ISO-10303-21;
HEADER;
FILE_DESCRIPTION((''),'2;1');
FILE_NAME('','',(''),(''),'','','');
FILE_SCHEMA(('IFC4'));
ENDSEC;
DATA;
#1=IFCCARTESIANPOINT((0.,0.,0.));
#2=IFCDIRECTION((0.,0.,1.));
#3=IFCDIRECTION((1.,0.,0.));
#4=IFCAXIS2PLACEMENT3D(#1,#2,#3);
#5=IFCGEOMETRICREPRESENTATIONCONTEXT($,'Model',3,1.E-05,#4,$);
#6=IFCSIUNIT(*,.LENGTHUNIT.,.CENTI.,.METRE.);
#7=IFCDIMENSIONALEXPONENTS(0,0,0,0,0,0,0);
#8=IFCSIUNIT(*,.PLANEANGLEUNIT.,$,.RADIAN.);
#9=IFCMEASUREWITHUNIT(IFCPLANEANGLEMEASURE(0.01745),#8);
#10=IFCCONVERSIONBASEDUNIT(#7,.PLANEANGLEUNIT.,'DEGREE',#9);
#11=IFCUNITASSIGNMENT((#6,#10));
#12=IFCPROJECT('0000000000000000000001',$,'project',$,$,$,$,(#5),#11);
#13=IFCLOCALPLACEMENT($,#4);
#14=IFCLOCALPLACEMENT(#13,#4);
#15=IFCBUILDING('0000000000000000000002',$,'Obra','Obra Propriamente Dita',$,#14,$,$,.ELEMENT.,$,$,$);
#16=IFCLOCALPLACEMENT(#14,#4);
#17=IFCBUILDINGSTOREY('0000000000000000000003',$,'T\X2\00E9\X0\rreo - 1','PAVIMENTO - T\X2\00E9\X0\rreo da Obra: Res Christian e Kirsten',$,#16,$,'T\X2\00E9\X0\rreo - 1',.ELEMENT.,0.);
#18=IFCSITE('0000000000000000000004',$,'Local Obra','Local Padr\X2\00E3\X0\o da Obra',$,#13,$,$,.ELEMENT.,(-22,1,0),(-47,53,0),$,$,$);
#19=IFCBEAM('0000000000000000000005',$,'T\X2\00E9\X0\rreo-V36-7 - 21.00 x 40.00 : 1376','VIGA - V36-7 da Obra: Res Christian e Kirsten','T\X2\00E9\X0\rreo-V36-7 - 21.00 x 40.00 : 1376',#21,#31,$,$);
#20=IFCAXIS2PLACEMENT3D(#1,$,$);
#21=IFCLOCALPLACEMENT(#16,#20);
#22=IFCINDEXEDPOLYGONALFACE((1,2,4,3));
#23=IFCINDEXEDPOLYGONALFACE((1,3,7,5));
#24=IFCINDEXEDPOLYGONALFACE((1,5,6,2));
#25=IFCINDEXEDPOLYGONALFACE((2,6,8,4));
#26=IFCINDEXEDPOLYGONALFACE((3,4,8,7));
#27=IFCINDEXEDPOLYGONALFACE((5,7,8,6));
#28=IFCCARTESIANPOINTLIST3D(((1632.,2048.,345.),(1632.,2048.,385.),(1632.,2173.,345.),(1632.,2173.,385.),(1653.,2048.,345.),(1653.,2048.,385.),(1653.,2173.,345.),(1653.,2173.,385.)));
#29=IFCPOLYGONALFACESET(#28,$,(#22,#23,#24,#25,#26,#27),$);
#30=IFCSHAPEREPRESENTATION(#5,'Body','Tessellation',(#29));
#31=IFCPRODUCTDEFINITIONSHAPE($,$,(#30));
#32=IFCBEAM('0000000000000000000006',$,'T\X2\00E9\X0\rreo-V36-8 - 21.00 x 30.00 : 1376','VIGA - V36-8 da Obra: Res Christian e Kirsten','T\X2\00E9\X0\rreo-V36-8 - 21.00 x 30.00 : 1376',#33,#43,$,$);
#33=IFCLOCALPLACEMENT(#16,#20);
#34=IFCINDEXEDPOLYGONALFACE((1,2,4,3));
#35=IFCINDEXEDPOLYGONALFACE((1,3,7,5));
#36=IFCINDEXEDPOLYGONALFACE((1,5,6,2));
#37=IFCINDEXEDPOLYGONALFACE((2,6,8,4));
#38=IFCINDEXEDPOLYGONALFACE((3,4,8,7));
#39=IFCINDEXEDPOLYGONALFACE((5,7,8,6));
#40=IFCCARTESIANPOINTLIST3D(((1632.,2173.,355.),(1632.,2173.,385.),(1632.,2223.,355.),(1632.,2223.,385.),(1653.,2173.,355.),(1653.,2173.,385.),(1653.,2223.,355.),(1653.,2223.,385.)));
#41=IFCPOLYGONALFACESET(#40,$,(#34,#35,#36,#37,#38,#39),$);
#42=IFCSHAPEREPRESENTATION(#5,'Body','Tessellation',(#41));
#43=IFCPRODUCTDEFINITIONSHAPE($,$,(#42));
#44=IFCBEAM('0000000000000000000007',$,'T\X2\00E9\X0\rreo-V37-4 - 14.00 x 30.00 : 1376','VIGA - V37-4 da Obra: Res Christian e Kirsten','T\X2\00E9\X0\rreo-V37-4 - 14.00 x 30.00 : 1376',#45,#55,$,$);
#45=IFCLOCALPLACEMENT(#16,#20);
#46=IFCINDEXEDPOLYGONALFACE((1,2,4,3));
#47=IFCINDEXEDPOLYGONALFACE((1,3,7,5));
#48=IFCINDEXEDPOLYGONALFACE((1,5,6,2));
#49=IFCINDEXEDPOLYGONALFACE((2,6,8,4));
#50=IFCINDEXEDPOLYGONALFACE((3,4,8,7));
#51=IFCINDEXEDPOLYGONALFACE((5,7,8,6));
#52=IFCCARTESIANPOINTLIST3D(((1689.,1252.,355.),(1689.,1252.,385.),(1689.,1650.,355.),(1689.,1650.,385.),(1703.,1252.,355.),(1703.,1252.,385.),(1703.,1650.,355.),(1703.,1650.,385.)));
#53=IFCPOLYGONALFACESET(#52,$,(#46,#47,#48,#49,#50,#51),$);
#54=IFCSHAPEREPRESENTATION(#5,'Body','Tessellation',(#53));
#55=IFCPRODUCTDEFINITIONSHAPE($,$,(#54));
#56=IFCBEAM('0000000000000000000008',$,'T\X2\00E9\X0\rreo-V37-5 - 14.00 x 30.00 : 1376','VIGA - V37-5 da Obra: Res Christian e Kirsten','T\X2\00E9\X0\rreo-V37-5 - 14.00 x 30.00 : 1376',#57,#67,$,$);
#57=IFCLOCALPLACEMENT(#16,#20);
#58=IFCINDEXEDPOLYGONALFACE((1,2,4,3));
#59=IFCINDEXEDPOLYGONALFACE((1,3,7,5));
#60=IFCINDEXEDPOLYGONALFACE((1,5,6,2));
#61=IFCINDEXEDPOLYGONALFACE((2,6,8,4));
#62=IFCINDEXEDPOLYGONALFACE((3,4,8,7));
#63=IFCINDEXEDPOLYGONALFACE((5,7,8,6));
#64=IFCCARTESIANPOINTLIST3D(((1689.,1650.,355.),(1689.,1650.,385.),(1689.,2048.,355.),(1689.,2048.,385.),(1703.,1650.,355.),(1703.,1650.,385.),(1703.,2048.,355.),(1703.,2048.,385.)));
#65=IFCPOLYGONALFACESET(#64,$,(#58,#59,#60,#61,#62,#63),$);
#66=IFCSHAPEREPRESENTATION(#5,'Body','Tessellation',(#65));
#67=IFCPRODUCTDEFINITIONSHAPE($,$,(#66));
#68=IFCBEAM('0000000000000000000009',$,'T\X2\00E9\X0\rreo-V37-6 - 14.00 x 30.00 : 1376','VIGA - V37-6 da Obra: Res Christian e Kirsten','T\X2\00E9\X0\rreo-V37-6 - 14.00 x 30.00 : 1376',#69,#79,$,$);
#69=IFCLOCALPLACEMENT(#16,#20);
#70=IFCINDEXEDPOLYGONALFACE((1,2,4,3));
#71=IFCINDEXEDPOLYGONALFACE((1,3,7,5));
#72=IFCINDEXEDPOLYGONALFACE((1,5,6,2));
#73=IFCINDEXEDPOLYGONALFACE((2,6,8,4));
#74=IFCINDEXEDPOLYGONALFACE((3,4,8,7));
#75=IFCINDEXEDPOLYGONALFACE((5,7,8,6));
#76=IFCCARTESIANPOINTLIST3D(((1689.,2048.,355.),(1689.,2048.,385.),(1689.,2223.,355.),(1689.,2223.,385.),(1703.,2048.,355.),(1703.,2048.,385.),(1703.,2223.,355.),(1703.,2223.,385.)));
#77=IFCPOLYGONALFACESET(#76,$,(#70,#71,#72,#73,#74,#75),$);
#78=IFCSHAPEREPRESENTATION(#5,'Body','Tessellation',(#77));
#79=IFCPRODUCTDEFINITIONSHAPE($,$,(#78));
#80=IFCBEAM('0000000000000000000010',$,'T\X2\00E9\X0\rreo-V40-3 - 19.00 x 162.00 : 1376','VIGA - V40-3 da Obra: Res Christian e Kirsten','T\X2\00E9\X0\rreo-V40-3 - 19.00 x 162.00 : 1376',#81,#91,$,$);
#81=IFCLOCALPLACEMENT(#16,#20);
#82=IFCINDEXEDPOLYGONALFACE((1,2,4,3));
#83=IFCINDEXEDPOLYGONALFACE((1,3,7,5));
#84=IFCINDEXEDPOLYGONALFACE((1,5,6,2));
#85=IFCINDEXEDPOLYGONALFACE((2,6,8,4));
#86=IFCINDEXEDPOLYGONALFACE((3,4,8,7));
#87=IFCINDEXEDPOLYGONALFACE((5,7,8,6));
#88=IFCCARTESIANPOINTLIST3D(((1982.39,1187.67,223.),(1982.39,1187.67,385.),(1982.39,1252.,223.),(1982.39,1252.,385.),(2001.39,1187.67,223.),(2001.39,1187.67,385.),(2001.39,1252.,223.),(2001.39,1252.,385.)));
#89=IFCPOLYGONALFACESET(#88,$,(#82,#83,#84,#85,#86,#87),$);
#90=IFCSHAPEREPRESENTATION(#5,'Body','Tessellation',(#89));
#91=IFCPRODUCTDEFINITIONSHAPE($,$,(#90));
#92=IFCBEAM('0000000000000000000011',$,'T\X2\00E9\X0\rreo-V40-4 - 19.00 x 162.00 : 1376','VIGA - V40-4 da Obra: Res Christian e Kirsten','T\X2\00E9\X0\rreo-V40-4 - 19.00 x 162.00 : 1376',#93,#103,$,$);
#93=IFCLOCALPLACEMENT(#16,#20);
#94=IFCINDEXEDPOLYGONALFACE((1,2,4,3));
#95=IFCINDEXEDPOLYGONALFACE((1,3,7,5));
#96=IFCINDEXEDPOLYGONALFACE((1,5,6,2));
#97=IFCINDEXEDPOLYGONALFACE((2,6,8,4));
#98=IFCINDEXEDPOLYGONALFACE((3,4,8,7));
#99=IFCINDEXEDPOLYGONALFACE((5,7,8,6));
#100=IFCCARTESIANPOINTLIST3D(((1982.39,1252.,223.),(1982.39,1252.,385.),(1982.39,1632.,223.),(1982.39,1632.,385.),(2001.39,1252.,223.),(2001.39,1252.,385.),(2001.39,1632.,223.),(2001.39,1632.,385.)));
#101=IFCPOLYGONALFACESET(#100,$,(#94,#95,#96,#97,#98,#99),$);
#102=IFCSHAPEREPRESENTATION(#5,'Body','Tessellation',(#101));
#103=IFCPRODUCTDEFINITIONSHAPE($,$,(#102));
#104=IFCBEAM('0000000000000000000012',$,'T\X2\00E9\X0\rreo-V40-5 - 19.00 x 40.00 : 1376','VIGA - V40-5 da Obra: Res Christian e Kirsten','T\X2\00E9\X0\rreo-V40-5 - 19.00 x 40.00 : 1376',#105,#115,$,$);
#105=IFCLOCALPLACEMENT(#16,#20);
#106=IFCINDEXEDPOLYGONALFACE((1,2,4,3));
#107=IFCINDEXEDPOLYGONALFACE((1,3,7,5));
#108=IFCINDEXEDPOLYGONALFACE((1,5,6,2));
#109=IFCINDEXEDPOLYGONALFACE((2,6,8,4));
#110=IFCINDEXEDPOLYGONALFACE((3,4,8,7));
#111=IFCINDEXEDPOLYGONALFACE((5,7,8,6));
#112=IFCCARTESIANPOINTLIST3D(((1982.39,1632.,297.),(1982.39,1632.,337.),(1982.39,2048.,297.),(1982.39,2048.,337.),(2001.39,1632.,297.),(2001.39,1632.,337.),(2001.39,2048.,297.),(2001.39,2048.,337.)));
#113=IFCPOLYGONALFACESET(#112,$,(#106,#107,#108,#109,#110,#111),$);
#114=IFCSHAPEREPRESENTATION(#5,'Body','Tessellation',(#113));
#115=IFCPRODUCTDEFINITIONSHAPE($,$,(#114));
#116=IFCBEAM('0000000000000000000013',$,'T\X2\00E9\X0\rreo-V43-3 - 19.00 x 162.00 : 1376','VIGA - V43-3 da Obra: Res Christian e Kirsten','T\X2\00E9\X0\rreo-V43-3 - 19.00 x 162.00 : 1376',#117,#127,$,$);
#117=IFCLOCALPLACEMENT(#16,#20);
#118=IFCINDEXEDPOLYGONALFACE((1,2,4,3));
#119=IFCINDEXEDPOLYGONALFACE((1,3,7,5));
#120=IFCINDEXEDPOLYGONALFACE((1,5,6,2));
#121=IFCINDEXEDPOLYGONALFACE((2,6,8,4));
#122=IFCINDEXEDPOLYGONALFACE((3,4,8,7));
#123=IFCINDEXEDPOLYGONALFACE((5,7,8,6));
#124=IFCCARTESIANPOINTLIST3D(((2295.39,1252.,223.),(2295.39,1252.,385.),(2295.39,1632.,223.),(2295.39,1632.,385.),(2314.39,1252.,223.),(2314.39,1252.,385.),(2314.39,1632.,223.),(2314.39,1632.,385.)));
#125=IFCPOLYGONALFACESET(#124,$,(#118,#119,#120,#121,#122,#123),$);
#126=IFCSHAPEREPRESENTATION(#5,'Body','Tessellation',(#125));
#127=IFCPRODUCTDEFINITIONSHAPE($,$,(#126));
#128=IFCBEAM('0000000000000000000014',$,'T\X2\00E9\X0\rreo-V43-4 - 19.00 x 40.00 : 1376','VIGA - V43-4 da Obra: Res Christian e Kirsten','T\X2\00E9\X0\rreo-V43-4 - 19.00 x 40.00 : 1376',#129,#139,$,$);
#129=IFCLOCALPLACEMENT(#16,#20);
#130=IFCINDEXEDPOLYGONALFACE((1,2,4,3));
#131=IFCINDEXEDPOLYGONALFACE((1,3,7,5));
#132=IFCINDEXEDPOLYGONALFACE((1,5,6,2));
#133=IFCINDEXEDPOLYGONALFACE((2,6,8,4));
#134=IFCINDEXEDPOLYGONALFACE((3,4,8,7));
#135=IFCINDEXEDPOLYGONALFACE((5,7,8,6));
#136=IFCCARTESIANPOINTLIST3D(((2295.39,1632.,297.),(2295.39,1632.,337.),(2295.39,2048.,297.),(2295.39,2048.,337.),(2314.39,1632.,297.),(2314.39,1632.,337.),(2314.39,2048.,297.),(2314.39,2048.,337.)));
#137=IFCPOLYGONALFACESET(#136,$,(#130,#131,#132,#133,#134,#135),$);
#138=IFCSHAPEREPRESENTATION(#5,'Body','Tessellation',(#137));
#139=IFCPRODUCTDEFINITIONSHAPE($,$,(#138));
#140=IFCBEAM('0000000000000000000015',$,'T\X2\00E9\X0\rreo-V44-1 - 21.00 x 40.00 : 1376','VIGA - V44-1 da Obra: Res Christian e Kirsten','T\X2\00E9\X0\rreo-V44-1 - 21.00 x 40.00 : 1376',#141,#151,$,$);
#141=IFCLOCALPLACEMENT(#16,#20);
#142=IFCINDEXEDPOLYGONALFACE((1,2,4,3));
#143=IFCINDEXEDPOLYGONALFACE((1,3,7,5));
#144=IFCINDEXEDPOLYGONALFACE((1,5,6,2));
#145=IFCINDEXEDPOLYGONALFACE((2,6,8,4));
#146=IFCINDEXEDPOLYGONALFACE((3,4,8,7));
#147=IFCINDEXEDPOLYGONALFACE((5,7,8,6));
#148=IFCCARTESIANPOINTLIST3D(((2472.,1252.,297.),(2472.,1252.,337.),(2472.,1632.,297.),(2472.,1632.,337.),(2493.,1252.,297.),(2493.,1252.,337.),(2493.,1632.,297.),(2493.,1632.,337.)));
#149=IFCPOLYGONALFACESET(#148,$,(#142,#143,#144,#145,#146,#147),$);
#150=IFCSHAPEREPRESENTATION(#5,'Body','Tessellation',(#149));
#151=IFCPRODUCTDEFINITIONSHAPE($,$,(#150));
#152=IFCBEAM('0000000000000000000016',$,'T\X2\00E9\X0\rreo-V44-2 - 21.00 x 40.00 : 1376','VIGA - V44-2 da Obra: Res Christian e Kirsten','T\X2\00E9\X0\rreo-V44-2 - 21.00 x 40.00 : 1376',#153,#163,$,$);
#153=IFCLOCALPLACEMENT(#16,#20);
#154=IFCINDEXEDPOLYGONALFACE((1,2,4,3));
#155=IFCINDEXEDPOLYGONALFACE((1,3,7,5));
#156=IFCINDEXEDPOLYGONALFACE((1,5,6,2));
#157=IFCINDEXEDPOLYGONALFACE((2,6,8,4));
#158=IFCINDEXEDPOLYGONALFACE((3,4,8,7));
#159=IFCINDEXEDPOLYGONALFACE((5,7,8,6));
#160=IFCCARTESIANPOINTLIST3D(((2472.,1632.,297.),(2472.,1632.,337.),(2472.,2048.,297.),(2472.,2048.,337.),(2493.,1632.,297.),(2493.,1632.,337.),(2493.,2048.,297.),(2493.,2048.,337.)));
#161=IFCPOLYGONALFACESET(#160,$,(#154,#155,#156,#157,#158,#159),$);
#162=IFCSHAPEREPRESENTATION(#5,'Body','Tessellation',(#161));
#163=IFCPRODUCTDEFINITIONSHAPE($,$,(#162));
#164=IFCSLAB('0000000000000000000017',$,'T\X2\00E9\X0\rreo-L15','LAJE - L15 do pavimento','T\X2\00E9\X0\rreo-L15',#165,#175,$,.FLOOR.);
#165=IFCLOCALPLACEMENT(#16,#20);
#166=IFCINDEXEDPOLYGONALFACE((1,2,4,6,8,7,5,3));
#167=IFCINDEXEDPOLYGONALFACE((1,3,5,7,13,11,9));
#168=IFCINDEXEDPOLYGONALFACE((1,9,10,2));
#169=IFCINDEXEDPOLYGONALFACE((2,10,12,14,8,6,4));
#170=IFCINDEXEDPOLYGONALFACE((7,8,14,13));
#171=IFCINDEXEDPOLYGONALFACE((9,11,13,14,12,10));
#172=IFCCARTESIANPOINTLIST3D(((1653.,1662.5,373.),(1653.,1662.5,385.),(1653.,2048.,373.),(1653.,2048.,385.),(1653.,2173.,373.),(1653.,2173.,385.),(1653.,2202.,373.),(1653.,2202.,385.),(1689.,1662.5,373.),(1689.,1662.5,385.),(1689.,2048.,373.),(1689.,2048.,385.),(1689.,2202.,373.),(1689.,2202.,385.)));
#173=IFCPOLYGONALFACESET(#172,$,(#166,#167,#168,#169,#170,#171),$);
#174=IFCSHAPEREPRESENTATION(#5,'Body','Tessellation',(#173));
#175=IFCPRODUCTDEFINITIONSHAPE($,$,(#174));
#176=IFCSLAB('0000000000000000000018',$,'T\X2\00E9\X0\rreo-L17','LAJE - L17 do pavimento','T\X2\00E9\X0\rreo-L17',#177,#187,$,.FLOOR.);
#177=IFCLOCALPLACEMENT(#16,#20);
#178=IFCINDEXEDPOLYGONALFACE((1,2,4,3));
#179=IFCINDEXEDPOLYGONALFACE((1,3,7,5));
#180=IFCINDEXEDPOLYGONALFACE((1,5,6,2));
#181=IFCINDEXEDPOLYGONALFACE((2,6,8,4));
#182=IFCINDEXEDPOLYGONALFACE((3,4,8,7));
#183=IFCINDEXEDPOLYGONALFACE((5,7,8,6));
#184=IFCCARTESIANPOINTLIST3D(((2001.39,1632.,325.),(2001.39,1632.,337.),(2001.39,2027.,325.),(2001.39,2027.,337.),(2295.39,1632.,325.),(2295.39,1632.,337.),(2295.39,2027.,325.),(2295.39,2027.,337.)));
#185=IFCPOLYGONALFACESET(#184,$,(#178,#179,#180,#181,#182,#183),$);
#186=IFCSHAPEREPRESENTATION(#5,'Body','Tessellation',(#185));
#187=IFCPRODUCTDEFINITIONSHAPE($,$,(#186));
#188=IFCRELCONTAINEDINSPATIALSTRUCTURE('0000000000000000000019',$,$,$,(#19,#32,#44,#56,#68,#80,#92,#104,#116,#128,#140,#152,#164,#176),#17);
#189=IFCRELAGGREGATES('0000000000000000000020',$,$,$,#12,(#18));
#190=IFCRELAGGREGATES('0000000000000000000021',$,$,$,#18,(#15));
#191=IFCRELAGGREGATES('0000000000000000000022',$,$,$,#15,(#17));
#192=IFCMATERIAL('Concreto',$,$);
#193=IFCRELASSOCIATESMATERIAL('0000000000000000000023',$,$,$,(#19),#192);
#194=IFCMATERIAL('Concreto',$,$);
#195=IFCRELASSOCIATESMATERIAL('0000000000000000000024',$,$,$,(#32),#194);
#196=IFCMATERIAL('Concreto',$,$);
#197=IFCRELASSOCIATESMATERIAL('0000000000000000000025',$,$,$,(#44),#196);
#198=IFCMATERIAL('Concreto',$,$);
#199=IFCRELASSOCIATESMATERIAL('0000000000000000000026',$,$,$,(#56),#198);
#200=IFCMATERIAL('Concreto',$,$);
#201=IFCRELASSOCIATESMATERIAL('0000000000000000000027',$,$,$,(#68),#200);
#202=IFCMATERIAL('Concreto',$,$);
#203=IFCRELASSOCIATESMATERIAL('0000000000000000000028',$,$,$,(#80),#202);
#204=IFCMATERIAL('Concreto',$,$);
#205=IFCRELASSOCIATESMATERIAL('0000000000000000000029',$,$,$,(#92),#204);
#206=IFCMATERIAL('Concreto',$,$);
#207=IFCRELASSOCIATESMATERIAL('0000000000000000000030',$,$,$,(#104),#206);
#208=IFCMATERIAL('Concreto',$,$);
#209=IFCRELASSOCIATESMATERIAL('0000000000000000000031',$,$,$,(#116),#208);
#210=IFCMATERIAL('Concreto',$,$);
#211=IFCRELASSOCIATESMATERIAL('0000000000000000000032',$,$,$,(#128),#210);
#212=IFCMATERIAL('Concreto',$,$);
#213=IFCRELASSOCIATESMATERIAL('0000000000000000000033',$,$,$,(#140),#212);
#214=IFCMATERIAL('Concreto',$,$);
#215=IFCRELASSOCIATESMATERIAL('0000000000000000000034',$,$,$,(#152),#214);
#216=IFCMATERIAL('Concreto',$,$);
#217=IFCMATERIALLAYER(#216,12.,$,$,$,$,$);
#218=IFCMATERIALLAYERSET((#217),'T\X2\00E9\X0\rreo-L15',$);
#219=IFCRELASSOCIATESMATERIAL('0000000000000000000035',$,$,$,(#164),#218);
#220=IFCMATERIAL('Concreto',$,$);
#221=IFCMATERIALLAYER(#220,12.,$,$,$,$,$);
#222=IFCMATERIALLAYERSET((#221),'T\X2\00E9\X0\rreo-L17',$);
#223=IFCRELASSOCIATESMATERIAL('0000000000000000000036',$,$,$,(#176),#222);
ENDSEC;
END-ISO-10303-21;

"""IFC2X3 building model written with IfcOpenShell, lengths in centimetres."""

from ifc_helpers import new_model, entity, si_unit, converted_unit, frame, origin_with_axes, place, context, project, spatial, polyline, outline, extrude, material, layer, layer_set, layer_usage, element, save


model = new_model("IFC2X3")

# Units and contexts
model_context = context("Model", 3, precision=1e-05, world=origin_with_axes())
ifc_project = project(units=[si_unit("LENGTHUNIT", "METRE", prefix="CENTI"), converted_unit("PLANEANGLEUNIT", "DEGREE", entity("IfcPlaneAngleMeasure", 0.01745), si_unit("PLANEANGLEUNIT", "RADIAN"), dimensions=[0, 0, 0, 0, 0, 0, 0])], contexts=[model_context])

# Site, building, storey
site_placement = place(None, origin_with_axes())
site = spatial("IfcSite", under=ifc_project, at=site_placement, Name="Local Obra", Description="Local Padrão da Obra", CompositionType="ELEMENT", RefLatitude=(-22, 1, 0), RefLongitude=(-47, 53, 0))
building_placement = place(site_placement, origin_with_axes())
building = spatial("IfcBuilding", under=site, at=building_placement, Name="Obra", Description="Obra Propriamente Dita", CompositionType="ELEMENT")
storey_placement = place(building_placement, origin_with_axes())
storey = spatial("IfcBuildingStorey", under=building, at=storey_placement, Name="Térreo - 1", Description="PAVIMENTO - Térreo da Obra: Res Christian e Kirsten", LongName="Térreo - 1", CompositionType="ELEMENT", Elevation=0.0)

# Beams
ifc_material_1 = material(Name="Concreto")
beam_1_placement = place(storey_placement, frame((1653.0, 2048.0, 385.0), z_axis=(0.0, 1.0, 0.0), x_axis=(1.0, 0.0, 0.0)))
element("IfcBeam", 1, at=beam_1_placement, inside=storey, material=ifc_material_1, Name="Térreo-V36-7 - 21.00 x 40.00 : 1376", Description="VIGA - V36-7 da Obra: Res Christian e Kirsten", ObjectType="Térreo-V36-7 - 21.00 x 40.00 : 1376", context=model_context, shape_type="SweptSolid", body=[
    extrude(outline(polyline([(-21.0, 0.0), (0.0, 0.0), (0.0, 40.0), (-21.0, 40.0), (-21.0, 0.0)])), origin_with_axes(), (0.0, 0.0, 1.0), 125.0),
])
ifc_material_2 = material(Name="Concreto")
beam_2_placement = place(storey_placement, frame((1653.0, 2173.0, 385.0), z_axis=(0.0, 1.0, 0.0), x_axis=(1.0, 0.0, 0.0)))
element("IfcBeam", 2, at=beam_2_placement, inside=storey, material=ifc_material_2, Name="Térreo-V36-8 - 21.00 x 30.00 : 1376", Description="VIGA - V36-8 da Obra: Res Christian e Kirsten", ObjectType="Térreo-V36-8 - 21.00 x 30.00 : 1376", context=model_context, shape_type="SweptSolid", body=[
    extrude(outline(polyline([(-21.0, 0.0), (0.0, 0.0), (0.0, 30.0), (-21.0, 30.0), (-21.0, 0.0)])), origin_with_axes(), (0.0, 0.0, 1.0), 50.0),
])
ifc_material_3 = material(Name="Concreto")
beam_3_placement = place(storey_placement, frame((1703.0, 1252.0, 385.0), z_axis=(0.0, 1.0, 0.0), x_axis=(1.0, 0.0, 0.0)))
element("IfcBeam", 3, at=beam_3_placement, inside=storey, material=ifc_material_3, Name="Térreo-V37-4 - 14.00 x 30.00 : 1376", Description="VIGA - V37-4 da Obra: Res Christian e Kirsten", ObjectType="Térreo-V37-4 - 14.00 x 30.00 : 1376", context=model_context, shape_type="SweptSolid", body=[
    extrude(outline(polyline([(-14.0, 0.0), (0.0, 0.0), (0.0, 30.0), (-14.0, 30.0), (-14.0, 0.0)])), origin_with_axes(), (0.0, 0.0, 1.0), 398.0),
])
ifc_material_4 = material(Name="Concreto")
beam_4_placement = place(storey_placement, frame((1703.0, 1650.0, 385.0), z_axis=(0.0, 1.0, 0.0), x_axis=(1.0, 0.0, 0.0)))
element("IfcBeam", 4, at=beam_4_placement, inside=storey, material=ifc_material_4, Name="Térreo-V37-5 - 14.00 x 30.00 : 1376", Description="VIGA - V37-5 da Obra: Res Christian e Kirsten", ObjectType="Térreo-V37-5 - 14.00 x 30.00 : 1376", context=model_context, shape_type="SweptSolid", body=[
    extrude(outline(polyline([(-14.0, 0.0), (0.0, 0.0), (0.0, 30.0), (-14.0, 30.0), (-14.0, 0.0)])), origin_with_axes(), (0.0, 0.0, 1.0), 398.0),
])
ifc_material_5 = material(Name="Concreto")
beam_5_placement = place(storey_placement, frame((1703.0, 2048.0, 385.0), z_axis=(0.0, 1.0, 0.0), x_axis=(1.0, 0.0, 0.0)))
element("IfcBeam", 5, at=beam_5_placement, inside=storey, material=ifc_material_5, Name="Térreo-V37-6 - 14.00 x 30.00 : 1376", Description="VIGA - V37-6 da Obra: Res Christian e Kirsten", ObjectType="Térreo-V37-6 - 14.00 x 30.00 : 1376", context=model_context, shape_type="SweptSolid", body=[
    extrude(outline(polyline([(-14.0, 0.0), (0.0, 0.0), (0.0, 30.0), (-14.0, 30.0), (-14.0, 0.0)])), origin_with_axes(), (0.0, 0.0, 1.0), 175.0),
])
ifc_material_6 = material(Name="Concreto")
beam_6_placement = place(storey_placement, frame((1982.39, 1187.67, 385.0), z_axis=(0.0, 1.0, 0.0), x_axis=(1.0, 0.0, 0.0)))
element("IfcBeam", 6, at=beam_6_placement, inside=storey, material=ifc_material_6, Name="Térreo-V40-3 - 19.00 x 162.00 : 1376", Description="VIGA - V40-3 da Obra: Res Christian e Kirsten", ObjectType="Térreo-V40-3 - 19.00 x 162.00 : 1376", context=model_context, shape_type="SweptSolid", body=[
    extrude(outline(polyline([(0.0, 0.0), (19.0, 0.0), (19.0, 162.0), (0.0, 162.0), (0.0, 0.0)])), origin_with_axes(), (0.0, 0.0, 1.0), 64.33),
])
ifc_material_7 = material(Name="Concreto")
beam_7_placement = place(storey_placement, frame((1982.39, 1252.0, 385.0), z_axis=(0.0, 1.0, 0.0), x_axis=(1.0, 0.0, 0.0)))
element("IfcBeam", 7, at=beam_7_placement, inside=storey, material=ifc_material_7, Name="Térreo-V40-4 - 19.00 x 162.00 : 1376", Description="VIGA - V40-4 da Obra: Res Christian e Kirsten", ObjectType="Térreo-V40-4 - 19.00 x 162.00 : 1376", context=model_context, shape_type="SweptSolid", body=[
    extrude(outline(polyline([(0.0, 0.0), (19.0, 0.0), (19.0, 162.0), (0.0, 162.0), (0.0, 0.0)])), origin_with_axes(), (0.0, 0.0, 1.0), 380.0),
])
ifc_material_8 = material(Name="Concreto")
beam_8_placement = place(storey_placement, frame((1982.39, 1632.0, 337.0), z_axis=(0.0, 1.0, 0.0), x_axis=(1.0, 0.0, 0.0)))
element("IfcBeam", 8, at=beam_8_placement, inside=storey, material=ifc_material_8, Name="Térreo-V40-5 - 19.00 x 40.00 : 1376", Description="VIGA - V40-5 da Obra: Res Christian e Kirsten", ObjectType="Térreo-V40-5 - 19.00 x 40.00 : 1376", context=model_context, shape_type="SweptSolid", body=[
    extrude(outline(polyline([(0.0, 0.0), (19.0, 0.0), (19.0, 40.0), (0.0, 40.0), (0.0, 0.0)])), origin_with_axes(), (0.0, 0.0, 1.0), 416.0),
])
ifc_material_9 = material(Name="Concreto")
beam_9_placement = place(storey_placement, frame((2314.39, 1252.0, 385.0), z_axis=(-0.000003, 1.0, 0.0), x_axis=(1.0, 0.000003, 0.0)))
element("IfcBeam", 9, at=beam_9_placement, inside=storey, material=ifc_material_9, Name="Térreo-V43-3 - 19.00 x 162.00 : 1376", Description="VIGA - V43-3 da Obra: Res Christian e Kirsten", ObjectType="Térreo-V43-3 - 19.00 x 162.00 : 1376", context=model_context, shape_type="SweptSolid", body=[
    extrude(outline(polyline([(-19.0, 0.0), (0.0, 0.0), (0.0, 162.0), (-19.0, 162.0), (-19.0, 0.0)])), origin_with_axes(), (0.0, 0.0, 1.0), 380.0),
])
ifc_material_10 = material(Name="Concreto")
beam_10_placement = place(storey_placement, frame((2314.39, 1632.0, 337.0), z_axis=(0.0, 1.0, 0.0), x_axis=(1.0, 0.0, 0.0)))
element("IfcBeam", 10, at=beam_10_placement, inside=storey, material=ifc_material_10, Name="Térreo-V43-4 - 19.00 x 40.00 : 1376", Description="VIGA - V43-4 da Obra: Res Christian e Kirsten", ObjectType="Térreo-V43-4 - 19.00 x 40.00 : 1376", context=model_context, shape_type="SweptSolid", body=[
    extrude(outline(polyline([(-19.0, 0.0), (0.0, 0.0), (0.0, 40.0), (-19.0, 40.0), (-19.0, 0.0)])), origin_with_axes(), (0.0, 0.0, 1.0), 416.0),
])
ifc_material_11 = material(Name="Concreto")
beam_11_placement = place(storey_placement, frame((2493.0, 1252.0, 337.0), z_axis=(0.0, 1.0, 0.0), x_axis=(1.0, 0.0, 0.0)))
element("IfcBeam", 11, at=beam_11_placement, inside=storey, material=ifc_material_11, Name="Térreo-V44-1 - 21.00 x 40.00 : 1376", Description="VIGA - V44-1 da Obra: Res Christian e Kirsten", ObjectType="Térreo-V44-1 - 21.00 x 40.00 : 1376", context=model_context, shape_type="SweptSolid", body=[
    extrude(outline(polyline([(-21.0, 0.0), (0.0, 0.0), (0.0, 40.0), (-21.0, 40.0), (-21.0, 0.0)])), origin_with_axes(), (0.0, 0.0, 1.0), 380.0),
])
ifc_material_12 = material(Name="Concreto")
beam_12_placement = place(storey_placement, frame((2493.0, 1632.0, 337.0), z_axis=(0.0, 1.0, 0.0), x_axis=(1.0, 0.0, 0.0)))
element("IfcBeam", 12, at=beam_12_placement, inside=storey, material=ifc_material_12, Name="Térreo-V44-2 - 21.00 x 40.00 : 1376", Description="VIGA - V44-2 da Obra: Res Christian e Kirsten", ObjectType="Térreo-V44-2 - 21.00 x 40.00 : 1376", context=model_context, shape_type="SweptSolid", body=[
    extrude(outline(polyline([(-21.0, 0.0), (0.0, 0.0), (0.0, 40.0), (-21.0, 40.0), (-21.0, 0.0)])), origin_with_axes(), (0.0, 0.0, 1.0), 416.0),
])

# Slabs
ifc_material_13 = material(Name="Concreto")
ifc_layer_1 = layer(ifc_material_13, 12.0)
ifc_layer_set_1 = layer_set([ifc_layer_1], Name="Térreo-L15")
ifc_layer_usage_1 = layer_usage(ifc_layer_set_1, "AXIS3", "POSITIVE", 0.0)
slab_1_placement = place(storey_placement, frame((1689.0, 2048.0, 373.0), z_axis=(0.0, 0.0, 1.0), x_axis=(1.0, 0.0, 0.0)))
element("IfcSlab", 13, at=slab_1_placement, inside=storey, material=ifc_layer_usage_1, Name="Térreo-L15", Description="LAJE - L15 do pavimento", ObjectType="Térreo-L15", PredefinedType="FLOOR", context=model_context, shape_type="SweptSolid", body=[
    extrude(outline(polyline([(0.0, 154.0), (-36.0, 154.0), (-36.0, 125.0), (-36.0, 0.0), (-36.0, -385.5), (0.0, -385.5), (0.0, 0.0), (0.0, 154.0)])), origin_with_axes(), (0.0, 0.0, 1.0), 12.0),
])
ifc_material_14 = material(Name="Concreto")
ifc_layer_2 = layer(ifc_material_14, 12.0)
ifc_layer_set_2 = layer_set([ifc_layer_2], Name="Térreo-L17")
ifc_layer_usage_2 = layer_usage(ifc_layer_set_2, "AXIS3", "POSITIVE", 0.0)
slab_2_placement = place(storey_placement, frame((2295.39, 1632.0, 325.0), z_axis=(0.0, 0.0, 1.0), x_axis=(1.0, 0.0, 0.0)))
element("IfcSlab", 14, at=slab_2_placement, inside=storey, material=ifc_layer_usage_2, Name="Térreo-L17", Description="LAJE - L17 do pavimento", ObjectType="Térreo-L17", PredefinedType="FLOOR", context=model_context, shape_type="SweptSolid", body=[
    extrude(outline(polyline([(0.0, 395.0), (-294.0, 395.0), (-294.0, 0.0), (0.0, 0.0), (0.0, 395.0)])), origin_with_axes(), (0.0, 0.0, 1.0), 12.0),
])

save(model, "model.ifc")
